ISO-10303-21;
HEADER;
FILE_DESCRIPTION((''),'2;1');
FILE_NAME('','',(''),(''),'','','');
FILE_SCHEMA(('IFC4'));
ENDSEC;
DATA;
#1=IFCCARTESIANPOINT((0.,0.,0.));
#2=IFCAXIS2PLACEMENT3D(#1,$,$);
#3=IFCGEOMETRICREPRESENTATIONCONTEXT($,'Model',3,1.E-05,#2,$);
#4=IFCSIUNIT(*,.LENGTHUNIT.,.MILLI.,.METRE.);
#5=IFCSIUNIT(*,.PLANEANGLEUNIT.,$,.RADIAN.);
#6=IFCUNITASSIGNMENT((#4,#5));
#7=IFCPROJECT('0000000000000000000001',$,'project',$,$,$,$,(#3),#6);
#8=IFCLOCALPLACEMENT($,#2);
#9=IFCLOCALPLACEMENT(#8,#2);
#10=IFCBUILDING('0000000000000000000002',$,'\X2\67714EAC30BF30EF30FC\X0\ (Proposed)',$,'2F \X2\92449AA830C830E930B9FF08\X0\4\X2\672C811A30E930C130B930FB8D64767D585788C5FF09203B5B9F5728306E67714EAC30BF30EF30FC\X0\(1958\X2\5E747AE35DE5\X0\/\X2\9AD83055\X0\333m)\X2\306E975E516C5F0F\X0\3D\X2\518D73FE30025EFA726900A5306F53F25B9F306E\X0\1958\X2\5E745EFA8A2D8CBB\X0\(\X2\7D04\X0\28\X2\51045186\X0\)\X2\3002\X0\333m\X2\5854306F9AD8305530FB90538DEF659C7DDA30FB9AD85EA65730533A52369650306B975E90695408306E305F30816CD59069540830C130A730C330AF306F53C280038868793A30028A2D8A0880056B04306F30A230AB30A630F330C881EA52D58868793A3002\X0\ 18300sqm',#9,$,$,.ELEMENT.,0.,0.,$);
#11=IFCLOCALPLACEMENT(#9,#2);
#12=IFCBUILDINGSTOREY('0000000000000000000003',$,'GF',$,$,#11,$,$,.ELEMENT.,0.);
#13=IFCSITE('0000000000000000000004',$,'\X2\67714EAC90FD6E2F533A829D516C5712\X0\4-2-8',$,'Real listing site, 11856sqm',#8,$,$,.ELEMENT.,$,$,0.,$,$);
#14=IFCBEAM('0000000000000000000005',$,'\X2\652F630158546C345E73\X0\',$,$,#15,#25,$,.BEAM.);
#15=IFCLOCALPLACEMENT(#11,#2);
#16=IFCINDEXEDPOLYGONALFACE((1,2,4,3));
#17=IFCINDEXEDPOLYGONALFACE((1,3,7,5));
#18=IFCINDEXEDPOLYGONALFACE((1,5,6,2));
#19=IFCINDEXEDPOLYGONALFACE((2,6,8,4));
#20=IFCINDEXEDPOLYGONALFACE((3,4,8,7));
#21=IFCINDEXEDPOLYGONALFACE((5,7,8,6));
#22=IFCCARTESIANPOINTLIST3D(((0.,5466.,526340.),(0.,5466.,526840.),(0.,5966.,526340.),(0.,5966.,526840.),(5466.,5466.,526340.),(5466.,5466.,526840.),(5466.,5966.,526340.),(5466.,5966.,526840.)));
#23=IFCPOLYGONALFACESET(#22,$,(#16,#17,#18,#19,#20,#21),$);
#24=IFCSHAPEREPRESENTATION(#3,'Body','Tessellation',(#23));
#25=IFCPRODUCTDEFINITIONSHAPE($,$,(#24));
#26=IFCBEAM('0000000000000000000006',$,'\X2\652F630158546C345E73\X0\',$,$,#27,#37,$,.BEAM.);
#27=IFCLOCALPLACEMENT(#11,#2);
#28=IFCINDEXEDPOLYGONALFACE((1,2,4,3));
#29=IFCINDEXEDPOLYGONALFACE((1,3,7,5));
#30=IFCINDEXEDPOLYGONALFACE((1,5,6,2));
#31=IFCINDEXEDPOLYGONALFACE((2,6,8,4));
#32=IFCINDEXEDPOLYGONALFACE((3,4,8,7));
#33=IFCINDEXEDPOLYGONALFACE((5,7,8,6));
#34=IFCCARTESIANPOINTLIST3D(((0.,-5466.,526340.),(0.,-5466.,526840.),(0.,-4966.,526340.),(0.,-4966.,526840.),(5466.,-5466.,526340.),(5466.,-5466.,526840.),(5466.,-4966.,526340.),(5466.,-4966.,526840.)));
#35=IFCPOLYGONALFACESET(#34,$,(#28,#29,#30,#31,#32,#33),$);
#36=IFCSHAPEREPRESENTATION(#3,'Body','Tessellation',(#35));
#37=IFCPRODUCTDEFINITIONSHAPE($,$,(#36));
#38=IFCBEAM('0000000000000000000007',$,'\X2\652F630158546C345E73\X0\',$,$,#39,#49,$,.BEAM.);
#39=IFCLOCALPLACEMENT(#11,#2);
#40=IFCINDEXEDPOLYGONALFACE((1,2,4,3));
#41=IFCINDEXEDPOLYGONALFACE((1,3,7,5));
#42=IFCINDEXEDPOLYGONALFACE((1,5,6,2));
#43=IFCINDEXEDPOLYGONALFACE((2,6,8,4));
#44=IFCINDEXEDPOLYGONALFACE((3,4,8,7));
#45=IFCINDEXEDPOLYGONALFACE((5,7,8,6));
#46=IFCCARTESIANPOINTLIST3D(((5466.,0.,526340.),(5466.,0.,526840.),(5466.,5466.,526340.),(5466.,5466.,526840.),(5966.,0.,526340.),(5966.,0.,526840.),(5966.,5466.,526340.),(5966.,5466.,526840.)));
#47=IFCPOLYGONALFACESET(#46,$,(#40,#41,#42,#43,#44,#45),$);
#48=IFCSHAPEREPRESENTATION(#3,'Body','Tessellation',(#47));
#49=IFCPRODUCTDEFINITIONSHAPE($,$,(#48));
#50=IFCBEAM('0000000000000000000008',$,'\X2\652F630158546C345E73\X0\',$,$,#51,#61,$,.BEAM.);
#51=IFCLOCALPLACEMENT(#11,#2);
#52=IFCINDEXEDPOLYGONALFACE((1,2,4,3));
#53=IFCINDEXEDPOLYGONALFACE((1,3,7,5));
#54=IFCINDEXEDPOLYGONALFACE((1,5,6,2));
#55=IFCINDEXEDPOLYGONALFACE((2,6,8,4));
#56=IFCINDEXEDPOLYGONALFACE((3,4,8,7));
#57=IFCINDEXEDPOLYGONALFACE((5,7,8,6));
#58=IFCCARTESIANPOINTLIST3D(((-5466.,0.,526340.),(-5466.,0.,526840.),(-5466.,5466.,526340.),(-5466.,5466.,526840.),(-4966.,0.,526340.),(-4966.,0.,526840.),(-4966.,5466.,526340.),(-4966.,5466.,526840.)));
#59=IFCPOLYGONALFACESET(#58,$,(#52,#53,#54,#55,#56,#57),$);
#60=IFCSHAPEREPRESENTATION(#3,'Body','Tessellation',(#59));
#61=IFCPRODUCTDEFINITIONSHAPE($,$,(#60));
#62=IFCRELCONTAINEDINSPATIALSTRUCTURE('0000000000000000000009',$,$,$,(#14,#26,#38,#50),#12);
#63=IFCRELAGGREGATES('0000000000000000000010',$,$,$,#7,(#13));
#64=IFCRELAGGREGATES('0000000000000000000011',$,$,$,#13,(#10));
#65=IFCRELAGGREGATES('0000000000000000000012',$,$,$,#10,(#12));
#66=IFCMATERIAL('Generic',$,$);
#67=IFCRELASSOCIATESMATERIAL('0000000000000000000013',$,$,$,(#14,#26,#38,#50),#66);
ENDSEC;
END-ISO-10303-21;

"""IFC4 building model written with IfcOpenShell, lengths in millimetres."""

from ifc_helpers import new_model, si_unit, frame, frame_2d, origin, place, context, project, spatial, rectangle, extrude, material, element, save


model = new_model("IFC4")

# Units and contexts
model_context = context("Model", 3, precision=1e-05, world=origin())
ifc_project = project(units=[si_unit("LENGTHUNIT", "METRE", prefix="MILLI"), si_unit("PLANEANGLEUNIT", "RADIAN")], contexts=[model_context])

# Site, building, storey
site_placement = place(None, origin())
site = spatial("IfcSite", under=ifc_project, at=site_placement, Name="東京都港区芝公園4-2-8", ObjectType="Real listing site, 11856sqm", CompositionType="ELEMENT", RefElevation=0.0)
building_placement = place(site_placement, origin())
building = spatial("IfcBuilding", under=site, at=building_placement, Name="東京タワー (Proposed)", ObjectType="2F 鉄骨トラス（4本脚ラチス・赤白塗装）※実在の東京タワー(1958年竣工/高さ333m)の非公式3D再現。建物¥は史実の1958年建設費(約28億円)。333m塔は高さ・道路斜線・高度地区制限に非適合のため法適合チェックは参考表示。設計者欄はアカウント自動表示。 18300sqm", CompositionType="ELEMENT", ElevationOfRefHeight=0.0, ElevationOfTerrain=0.0)
storey_placement = place(building_placement, origin())
storey = spatial("IfcBuildingStorey", under=building, at=storey_placement, Name="GF", CompositionType="ELEMENT", Elevation=0.0)

# Shared definitions
ifc_material = material(Name="Generic")

# Beams
beam_1_placement = place(storey_placement, frame((0.0, 2733.0, 263170.0)))
element("IfcBeam", 1, at=beam_1_placement, inside=storey, material=ifc_material, Name="支持塔水平", PredefinedType="BEAM", context=model_context, shape_type="SweptSolid", body=[
    extrude(rectangle(XDim=5466.0, YDim=500.0, at=frame_2d((2733.0, 250.0))), frame((0.0, 2733.0, 263170.0)), (0.0, 0.0, 1.0), 500.0),
])
beam_2_placement = place(storey_placement, frame((0.0, -2733.0, 263170.0)))
element("IfcBeam", 2, at=beam_2_placement, inside=storey, material=ifc_material, Name="支持塔水平", PredefinedType="BEAM", context=model_context, shape_type="SweptSolid", body=[
    extrude(rectangle(XDim=5466.0, YDim=500.0, at=frame_2d((2733.0, 250.0))), frame((0.0, -2733.0, 263170.0)), (0.0, 0.0, 1.0), 500.0),
])
beam_3_placement = place(storey_placement, frame((2733.0, 0.0, 263170.0)))
element("IfcBeam", 3, at=beam_3_placement, inside=storey, material=ifc_material, Name="支持塔水平", PredefinedType="BEAM", context=model_context, shape_type="SweptSolid", body=[
    extrude(rectangle(XDim=500.0, YDim=5466.0, at=frame_2d((250.0, 2733.0))), frame((2733.0, 0.0, 263170.0)), (0.0, 0.0, 1.0), 500.0),
])
beam_4_placement = place(storey_placement, frame((-2733.0, 0.0, 263170.0)))
element("IfcBeam", 4, at=beam_4_placement, inside=storey, material=ifc_material, Name="支持塔水平", PredefinedType="BEAM", context=model_context, shape_type="SweptSolid", body=[
    extrude(rectangle(XDim=500.0, YDim=5466.0, at=frame_2d((250.0, 2733.0))), frame((-2733.0, 0.0, 263170.0)), (0.0, 0.0, 1.0), 500.0),
])

save(model, "model.ifc")
